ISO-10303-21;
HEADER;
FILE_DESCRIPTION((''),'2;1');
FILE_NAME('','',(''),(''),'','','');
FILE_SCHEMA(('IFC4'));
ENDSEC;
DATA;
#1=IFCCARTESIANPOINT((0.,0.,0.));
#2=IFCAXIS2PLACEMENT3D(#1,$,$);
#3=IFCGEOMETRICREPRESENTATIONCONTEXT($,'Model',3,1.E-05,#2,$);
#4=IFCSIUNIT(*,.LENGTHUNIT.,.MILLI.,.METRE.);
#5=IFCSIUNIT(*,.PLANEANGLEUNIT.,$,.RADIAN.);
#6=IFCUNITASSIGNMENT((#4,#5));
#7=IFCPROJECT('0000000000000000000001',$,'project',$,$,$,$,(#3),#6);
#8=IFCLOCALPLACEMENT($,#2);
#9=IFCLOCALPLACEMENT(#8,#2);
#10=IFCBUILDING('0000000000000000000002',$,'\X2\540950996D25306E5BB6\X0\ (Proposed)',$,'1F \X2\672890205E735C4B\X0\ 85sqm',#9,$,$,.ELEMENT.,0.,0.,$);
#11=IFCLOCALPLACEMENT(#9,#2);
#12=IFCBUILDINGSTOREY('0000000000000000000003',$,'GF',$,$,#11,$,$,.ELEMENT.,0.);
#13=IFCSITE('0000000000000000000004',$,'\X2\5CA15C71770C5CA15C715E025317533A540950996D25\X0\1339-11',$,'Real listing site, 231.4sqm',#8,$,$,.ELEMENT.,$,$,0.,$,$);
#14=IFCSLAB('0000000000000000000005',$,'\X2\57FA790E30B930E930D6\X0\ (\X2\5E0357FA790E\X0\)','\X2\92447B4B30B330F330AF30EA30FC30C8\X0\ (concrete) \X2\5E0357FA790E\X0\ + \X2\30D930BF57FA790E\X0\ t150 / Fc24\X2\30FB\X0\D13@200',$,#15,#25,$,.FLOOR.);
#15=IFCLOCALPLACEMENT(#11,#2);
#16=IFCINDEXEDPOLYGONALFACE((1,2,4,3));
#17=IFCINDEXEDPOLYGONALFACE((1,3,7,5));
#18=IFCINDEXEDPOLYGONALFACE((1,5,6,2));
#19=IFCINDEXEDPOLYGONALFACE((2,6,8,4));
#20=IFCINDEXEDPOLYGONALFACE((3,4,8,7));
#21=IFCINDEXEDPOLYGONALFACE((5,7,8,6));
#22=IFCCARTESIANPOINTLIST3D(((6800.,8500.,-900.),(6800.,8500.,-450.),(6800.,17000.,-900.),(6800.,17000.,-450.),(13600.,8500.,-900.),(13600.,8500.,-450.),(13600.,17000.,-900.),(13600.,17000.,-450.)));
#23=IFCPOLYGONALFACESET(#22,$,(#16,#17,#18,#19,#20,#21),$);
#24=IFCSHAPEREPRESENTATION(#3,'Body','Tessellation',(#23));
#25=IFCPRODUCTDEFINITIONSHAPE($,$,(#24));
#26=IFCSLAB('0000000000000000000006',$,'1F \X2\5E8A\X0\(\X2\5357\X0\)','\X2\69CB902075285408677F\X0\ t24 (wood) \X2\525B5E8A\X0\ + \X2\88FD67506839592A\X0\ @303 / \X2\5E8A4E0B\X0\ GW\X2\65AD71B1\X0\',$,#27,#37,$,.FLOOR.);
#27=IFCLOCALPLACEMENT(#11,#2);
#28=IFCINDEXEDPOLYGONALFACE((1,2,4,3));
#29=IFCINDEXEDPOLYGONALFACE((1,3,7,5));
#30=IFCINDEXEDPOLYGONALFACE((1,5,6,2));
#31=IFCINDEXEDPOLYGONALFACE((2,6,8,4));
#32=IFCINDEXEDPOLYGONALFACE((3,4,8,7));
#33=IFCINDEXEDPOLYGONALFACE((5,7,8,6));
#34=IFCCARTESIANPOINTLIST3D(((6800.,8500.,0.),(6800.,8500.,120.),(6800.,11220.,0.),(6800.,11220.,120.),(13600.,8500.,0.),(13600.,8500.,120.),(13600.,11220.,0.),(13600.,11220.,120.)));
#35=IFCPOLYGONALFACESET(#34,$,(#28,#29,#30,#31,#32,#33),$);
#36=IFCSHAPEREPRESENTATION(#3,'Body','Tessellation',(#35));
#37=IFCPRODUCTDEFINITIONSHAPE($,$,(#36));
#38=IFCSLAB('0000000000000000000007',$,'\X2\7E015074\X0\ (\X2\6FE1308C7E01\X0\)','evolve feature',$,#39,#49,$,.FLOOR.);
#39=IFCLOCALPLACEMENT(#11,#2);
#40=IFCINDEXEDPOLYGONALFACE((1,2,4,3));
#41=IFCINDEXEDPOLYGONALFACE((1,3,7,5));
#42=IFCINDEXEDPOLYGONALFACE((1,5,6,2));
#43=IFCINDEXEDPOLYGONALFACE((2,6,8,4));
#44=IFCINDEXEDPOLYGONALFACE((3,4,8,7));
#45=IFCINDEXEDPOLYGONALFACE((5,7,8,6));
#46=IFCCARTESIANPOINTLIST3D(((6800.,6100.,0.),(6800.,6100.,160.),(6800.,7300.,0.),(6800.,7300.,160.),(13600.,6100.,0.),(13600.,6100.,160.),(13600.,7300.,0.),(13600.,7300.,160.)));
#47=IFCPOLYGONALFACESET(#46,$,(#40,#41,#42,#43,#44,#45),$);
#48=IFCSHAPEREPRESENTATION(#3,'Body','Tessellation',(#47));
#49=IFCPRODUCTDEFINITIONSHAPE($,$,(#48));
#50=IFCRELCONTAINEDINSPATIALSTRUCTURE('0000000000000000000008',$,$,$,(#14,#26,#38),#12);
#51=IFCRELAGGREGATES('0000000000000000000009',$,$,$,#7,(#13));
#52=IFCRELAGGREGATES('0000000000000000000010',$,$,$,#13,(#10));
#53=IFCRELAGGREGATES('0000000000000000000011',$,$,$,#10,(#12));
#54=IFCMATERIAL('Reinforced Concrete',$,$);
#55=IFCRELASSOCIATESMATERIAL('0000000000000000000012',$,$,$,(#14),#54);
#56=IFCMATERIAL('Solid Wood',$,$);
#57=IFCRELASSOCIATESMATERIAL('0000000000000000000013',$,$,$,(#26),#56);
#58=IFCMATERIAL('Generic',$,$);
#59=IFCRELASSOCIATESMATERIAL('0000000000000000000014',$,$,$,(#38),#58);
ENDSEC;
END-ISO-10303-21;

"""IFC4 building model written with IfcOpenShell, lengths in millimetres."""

from ifc_helpers import new_model, si_unit, frame, frame_2d, origin, place, context, project, spatial, rectangle, extrude, material, element, save


model = new_model("IFC4")

# Units and contexts
model_context = context("Model", 3, precision=1e-05, world=origin())
ifc_project = project(units=[si_unit("LENGTHUNIT", "METRE", prefix="MILLI"), si_unit("PLANEANGLEUNIT", "RADIAN")], contexts=[model_context])

# Site, building, storey
site_placement = place(None, origin())
site = spatial("IfcSite", under=ifc_project, at=site_placement, Name="岡山県岡山市北区吉備津1339-11", ObjectType="Real listing site, 231.4sqm", CompositionType="ELEMENT", RefElevation=0.0)
building_placement = place(site_placement, origin())
building = spatial("IfcBuilding", under=site, at=building_placement, Name="吉備津の家 (Proposed)", ObjectType="1F 木造平屋 85sqm", CompositionType="ELEMENT", ElevationOfRefHeight=0.0, ElevationOfTerrain=0.0)
storey_placement = place(building_placement, origin())
storey = spatial("IfcBuildingStorey", under=building, at=storey_placement, Name="GF", CompositionType="ELEMENT", Elevation=0.0)

# Slabs
ifc_material_1 = material(Name="Reinforced Concrete")
slab_1_placement = place(storey_placement, frame((3400.0, 4250.0, -450.0)))
element("IfcSlab", 1, at=slab_1_placement, inside=storey, material=ifc_material_1, Name="基礎スラブ (布基礎)", Description="鉄筋コンクリート (concrete) 布基礎 + ベタ基礎 t150 / Fc24・D13@200", PredefinedType="FLOOR", context=model_context, shape_type="SweptSolid", body=[
    extrude(rectangle(XDim=6800.0, YDim=8500.0, at=frame_2d((3400.0, 4250.0))), frame((3400.0, 4250.0, -450.0)), (0.0, 0.0, 1.0), 450.0),
])
ifc_material_2 = material(Name="Solid Wood")
slab_2_placement = place(storey_placement, frame((3400.0, 4250.0, 0.0)))
element("IfcSlab", 2, at=slab_2_placement, inside=storey, material=ifc_material_2, Name="1F 床(南)", Description="構造用合板 t24 (wood) 剛床 + 製材根太 @303 / 床下 GW断熱", PredefinedType="FLOOR", context=model_context, shape_type="SweptSolid", body=[
    extrude(rectangle(XDim=6800.0, YDim=2720.0, at=frame_2d((3400.0, 1360.0))), frame((3400.0, 4250.0, 0.0)), (0.0, 0.0, 1.0), 120.0),
])
ifc_material_3 = material(Name="Generic")
slab_3_placement = place(storey_placement, frame((3400.0, 3050.0, 0.0)))
element("IfcSlab", 3, at=slab_3_placement, inside=storey, material=ifc_material_3, Name="縁側 (濡れ縁)", Description="evolve feature", PredefinedType="FLOOR", context=model_context, shape_type="SweptSolid", body=[
    extrude(rectangle(XDim=6800.0, YDim=1200.0, at=frame_2d((3400.0, 600.0))), frame((3400.0, 3050.0, 0.0)), (0.0, 0.0, 1.0), 160.0),
])

save(model, "model.ifc")
